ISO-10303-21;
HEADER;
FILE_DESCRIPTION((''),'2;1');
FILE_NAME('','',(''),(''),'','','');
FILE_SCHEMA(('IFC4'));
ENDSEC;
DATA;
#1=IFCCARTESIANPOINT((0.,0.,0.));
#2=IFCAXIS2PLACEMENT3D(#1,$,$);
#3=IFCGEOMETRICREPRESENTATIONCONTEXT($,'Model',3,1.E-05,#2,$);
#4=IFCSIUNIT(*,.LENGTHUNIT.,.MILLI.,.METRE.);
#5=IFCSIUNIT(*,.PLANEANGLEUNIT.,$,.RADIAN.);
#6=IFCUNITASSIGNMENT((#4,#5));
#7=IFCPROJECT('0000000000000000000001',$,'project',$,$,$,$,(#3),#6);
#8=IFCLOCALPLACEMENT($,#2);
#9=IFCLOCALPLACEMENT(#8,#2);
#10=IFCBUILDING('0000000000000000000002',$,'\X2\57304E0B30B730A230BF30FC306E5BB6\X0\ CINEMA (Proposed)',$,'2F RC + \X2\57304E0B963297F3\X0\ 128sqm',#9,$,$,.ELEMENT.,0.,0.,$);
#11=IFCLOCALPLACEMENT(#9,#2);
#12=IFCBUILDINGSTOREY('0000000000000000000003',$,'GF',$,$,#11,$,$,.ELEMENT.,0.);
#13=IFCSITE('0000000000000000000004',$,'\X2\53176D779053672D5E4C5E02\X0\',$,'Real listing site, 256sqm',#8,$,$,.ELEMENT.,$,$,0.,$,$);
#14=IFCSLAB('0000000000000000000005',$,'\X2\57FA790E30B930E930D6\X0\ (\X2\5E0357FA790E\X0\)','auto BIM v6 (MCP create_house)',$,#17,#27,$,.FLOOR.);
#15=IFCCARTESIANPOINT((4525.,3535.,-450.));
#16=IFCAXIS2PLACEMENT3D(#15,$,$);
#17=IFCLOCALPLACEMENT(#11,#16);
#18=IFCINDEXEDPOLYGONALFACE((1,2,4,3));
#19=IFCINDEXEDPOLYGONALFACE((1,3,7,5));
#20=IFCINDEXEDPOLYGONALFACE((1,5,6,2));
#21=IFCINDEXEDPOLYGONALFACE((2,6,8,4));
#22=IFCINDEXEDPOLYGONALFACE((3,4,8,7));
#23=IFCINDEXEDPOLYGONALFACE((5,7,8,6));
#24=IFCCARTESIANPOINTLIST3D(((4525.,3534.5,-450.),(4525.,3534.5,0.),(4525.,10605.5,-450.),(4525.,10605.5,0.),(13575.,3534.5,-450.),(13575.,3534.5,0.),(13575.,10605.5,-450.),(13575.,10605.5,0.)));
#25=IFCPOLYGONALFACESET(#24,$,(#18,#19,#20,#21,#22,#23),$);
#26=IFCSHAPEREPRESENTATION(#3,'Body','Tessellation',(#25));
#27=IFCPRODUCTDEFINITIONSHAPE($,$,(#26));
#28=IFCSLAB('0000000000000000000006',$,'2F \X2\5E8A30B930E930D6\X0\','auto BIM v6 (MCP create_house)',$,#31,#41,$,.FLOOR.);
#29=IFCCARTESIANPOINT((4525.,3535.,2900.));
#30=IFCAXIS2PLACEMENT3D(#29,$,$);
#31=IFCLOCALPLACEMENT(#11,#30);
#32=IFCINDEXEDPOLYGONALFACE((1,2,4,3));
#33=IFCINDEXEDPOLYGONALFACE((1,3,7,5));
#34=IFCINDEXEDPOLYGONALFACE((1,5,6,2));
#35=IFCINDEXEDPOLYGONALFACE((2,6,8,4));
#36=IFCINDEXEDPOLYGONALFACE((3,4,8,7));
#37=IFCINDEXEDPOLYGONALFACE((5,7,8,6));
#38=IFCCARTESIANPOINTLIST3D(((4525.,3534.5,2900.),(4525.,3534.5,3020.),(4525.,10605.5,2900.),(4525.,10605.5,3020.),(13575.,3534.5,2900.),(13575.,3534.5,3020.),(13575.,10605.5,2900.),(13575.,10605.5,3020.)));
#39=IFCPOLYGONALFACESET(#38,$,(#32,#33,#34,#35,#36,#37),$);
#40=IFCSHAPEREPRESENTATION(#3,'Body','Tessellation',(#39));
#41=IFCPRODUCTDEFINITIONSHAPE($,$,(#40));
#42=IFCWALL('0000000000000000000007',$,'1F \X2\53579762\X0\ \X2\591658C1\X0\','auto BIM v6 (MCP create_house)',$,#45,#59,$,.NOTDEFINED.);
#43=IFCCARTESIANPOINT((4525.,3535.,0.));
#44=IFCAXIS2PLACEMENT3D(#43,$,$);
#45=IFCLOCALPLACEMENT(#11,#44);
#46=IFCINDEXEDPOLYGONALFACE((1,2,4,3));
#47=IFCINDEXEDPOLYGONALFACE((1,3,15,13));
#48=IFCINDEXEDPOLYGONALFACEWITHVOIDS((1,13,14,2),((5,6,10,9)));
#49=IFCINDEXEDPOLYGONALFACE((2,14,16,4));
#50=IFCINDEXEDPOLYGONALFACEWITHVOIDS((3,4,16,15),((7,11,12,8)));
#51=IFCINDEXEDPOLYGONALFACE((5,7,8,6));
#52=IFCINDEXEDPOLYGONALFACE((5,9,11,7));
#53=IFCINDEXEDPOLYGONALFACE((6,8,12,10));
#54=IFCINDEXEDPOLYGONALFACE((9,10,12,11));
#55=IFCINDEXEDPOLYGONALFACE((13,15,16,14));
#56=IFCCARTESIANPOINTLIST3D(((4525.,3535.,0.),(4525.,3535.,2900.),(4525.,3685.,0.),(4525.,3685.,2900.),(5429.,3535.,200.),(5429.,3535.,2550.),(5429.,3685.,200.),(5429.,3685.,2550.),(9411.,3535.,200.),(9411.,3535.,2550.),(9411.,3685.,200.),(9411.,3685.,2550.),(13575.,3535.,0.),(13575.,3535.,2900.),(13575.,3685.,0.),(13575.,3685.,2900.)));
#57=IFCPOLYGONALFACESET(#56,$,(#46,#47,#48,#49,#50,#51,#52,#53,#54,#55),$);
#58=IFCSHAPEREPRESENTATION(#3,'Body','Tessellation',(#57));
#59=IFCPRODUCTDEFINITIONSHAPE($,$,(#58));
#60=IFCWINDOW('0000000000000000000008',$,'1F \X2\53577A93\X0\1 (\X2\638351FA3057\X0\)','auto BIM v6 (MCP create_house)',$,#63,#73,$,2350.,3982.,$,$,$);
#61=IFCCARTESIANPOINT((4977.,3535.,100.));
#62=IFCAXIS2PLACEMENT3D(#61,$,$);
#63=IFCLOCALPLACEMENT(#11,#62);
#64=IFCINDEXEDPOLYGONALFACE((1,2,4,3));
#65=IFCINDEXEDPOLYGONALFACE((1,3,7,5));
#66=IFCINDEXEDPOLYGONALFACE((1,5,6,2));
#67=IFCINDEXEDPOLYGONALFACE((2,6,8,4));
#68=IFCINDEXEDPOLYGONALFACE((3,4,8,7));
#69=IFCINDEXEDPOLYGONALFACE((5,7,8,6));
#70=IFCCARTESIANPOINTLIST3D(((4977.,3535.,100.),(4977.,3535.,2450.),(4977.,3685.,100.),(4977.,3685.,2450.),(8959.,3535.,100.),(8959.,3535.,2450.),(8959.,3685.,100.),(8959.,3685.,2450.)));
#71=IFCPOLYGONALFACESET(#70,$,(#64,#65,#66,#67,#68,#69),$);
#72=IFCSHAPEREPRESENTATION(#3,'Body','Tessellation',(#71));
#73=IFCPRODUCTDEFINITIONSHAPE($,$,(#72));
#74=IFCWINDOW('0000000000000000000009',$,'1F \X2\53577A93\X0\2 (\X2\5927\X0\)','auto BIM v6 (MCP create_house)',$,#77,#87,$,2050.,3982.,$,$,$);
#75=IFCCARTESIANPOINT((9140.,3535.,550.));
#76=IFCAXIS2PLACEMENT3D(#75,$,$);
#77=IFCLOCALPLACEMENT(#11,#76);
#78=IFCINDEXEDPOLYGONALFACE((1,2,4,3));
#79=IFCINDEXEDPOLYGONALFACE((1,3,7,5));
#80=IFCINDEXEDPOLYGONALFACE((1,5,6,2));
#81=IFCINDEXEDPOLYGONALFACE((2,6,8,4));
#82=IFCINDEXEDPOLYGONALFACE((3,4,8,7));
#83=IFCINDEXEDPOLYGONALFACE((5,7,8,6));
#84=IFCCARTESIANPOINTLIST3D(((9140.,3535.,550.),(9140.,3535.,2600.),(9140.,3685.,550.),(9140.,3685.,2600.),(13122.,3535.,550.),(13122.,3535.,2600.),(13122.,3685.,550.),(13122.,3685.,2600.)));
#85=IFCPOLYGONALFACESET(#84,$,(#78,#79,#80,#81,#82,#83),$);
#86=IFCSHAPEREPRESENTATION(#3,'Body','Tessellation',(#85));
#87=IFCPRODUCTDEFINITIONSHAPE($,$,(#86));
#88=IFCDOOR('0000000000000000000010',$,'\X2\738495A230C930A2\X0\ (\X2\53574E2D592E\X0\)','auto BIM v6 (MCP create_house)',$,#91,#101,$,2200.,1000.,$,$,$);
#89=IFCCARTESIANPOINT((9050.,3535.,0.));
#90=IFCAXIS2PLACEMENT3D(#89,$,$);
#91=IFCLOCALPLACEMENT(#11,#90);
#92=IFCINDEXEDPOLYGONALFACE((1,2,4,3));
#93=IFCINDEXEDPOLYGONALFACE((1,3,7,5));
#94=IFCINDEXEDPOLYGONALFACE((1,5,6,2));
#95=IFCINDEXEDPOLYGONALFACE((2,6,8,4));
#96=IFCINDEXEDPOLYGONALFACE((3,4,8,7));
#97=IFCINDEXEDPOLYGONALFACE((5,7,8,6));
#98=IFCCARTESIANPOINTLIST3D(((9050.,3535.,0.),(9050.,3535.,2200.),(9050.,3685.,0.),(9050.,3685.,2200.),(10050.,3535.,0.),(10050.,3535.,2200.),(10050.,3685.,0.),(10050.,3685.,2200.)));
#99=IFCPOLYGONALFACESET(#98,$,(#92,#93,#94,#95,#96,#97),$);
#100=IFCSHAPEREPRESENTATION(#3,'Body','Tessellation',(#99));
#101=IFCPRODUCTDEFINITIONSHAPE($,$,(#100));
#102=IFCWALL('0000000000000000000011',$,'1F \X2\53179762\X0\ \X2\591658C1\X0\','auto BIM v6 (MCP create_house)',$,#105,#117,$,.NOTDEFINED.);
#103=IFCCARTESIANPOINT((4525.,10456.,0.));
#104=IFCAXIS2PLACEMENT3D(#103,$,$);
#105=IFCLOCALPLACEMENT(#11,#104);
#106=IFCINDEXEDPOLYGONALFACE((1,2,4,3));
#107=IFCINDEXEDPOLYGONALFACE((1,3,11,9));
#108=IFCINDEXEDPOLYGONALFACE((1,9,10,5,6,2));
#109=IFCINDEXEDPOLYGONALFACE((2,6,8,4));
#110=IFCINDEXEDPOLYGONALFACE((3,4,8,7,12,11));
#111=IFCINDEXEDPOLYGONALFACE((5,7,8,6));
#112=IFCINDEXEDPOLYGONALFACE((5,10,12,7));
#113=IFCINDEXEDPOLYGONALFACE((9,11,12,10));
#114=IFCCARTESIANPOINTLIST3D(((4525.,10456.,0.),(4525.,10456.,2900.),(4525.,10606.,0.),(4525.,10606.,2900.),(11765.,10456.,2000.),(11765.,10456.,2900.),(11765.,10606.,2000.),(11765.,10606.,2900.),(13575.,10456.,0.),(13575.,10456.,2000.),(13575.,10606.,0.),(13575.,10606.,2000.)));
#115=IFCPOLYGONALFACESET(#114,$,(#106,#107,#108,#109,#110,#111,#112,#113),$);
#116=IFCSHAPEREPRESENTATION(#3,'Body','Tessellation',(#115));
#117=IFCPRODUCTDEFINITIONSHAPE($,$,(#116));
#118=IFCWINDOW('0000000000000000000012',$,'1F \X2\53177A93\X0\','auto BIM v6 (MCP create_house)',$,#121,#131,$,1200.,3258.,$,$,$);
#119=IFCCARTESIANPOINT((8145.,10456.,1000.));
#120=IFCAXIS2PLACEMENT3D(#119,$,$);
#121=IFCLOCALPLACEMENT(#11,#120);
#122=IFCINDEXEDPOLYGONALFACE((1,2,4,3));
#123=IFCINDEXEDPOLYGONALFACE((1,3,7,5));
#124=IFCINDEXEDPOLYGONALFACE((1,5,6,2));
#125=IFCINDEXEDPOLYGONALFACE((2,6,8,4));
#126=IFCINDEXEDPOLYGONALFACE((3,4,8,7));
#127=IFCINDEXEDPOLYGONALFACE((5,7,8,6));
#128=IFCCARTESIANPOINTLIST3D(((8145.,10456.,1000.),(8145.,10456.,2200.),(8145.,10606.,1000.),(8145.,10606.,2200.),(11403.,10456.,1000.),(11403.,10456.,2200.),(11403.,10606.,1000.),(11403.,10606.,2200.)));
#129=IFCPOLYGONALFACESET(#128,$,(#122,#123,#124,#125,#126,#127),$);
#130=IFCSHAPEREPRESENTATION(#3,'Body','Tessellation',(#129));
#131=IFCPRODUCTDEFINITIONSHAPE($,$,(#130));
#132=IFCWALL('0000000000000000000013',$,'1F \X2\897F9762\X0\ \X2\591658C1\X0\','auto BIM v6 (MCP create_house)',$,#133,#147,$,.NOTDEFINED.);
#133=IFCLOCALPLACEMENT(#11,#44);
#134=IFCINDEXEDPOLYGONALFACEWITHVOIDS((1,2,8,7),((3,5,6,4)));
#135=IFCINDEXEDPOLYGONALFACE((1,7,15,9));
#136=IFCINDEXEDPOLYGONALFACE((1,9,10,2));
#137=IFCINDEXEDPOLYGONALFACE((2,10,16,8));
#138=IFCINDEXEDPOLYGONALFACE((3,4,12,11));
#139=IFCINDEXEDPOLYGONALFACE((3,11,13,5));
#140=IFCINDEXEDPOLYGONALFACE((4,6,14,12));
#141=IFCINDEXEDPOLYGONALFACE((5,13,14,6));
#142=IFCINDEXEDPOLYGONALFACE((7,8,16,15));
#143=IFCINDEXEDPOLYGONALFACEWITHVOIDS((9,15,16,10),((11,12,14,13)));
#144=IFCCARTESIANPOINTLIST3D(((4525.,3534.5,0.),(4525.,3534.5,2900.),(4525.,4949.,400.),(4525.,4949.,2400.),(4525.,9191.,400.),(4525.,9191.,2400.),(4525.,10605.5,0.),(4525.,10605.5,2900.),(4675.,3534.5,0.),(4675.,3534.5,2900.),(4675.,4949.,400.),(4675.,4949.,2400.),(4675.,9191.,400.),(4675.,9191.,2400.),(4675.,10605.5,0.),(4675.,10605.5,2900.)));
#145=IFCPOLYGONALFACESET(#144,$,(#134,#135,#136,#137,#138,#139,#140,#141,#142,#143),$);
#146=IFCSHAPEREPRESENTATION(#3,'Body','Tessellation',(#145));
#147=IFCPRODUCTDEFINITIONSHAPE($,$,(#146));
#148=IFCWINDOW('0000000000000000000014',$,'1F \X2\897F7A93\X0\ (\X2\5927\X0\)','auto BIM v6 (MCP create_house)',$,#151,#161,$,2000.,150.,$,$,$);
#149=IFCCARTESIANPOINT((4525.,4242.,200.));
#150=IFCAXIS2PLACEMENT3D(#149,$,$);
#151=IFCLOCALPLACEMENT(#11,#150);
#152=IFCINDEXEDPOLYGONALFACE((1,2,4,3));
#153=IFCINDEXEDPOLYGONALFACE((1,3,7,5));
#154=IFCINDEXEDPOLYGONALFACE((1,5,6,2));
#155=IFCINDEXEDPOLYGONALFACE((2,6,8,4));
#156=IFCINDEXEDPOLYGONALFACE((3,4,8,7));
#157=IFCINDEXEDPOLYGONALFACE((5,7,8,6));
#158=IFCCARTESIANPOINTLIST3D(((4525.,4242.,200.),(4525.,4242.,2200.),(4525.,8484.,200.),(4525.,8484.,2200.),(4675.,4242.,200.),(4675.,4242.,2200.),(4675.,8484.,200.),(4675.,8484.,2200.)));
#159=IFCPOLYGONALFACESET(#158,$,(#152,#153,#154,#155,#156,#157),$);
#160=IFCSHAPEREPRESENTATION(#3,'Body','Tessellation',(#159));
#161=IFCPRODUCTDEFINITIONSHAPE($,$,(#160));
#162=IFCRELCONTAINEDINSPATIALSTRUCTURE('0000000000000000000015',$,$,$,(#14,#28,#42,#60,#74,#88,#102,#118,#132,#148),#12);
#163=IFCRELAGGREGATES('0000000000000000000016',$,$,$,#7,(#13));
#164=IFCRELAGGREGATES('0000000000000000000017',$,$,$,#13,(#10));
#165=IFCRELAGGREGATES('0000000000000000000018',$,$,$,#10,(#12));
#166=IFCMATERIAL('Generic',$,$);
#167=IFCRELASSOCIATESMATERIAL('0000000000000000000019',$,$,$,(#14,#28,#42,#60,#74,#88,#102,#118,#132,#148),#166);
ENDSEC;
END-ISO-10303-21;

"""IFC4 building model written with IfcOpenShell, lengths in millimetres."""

from ifc_helpers import new_model, si_unit, frame, frame_2d, origin, place, context, project, spatial, rectangle, extrude, material, element, fill, save


model = new_model("IFC4")

# Units and contexts
model_context = context("Model", 3, precision=1e-05, world=origin())
ifc_project = project(units=[si_unit("LENGTHUNIT", "METRE", prefix="MILLI"), si_unit("PLANEANGLEUNIT", "RADIAN")], contexts=[model_context])

# Site, building, storey
site_placement = place(None, origin())
site = spatial("IfcSite", under=ifc_project, at=site_placement, Name="北海道札幌市", ObjectType="Real listing site, 256sqm", CompositionType="ELEMENT", RefElevation=0.0)
building_placement = place(site_placement, origin())
building = spatial("IfcBuilding", under=site, at=building_placement, Name="地下シアターの家 CINEMA (Proposed)", ObjectType="2F RC + 地下防音 128sqm", CompositionType="ELEMENT", ElevationOfRefHeight=0.0, ElevationOfTerrain=0.0)
storey_placement = place(building_placement, origin())
storey = spatial("IfcBuildingStorey", under=building, at=storey_placement, Name="GF", CompositionType="ELEMENT", Elevation=0.0)

# Slabs
ifc_material = material(Name="Generic")
slab_1_placement = place(storey_placement, frame((4525.0, 3535.0, -450.0)))
element("IfcSlab", 1, at=slab_1_placement, inside=storey, material=ifc_material, Name="基礎スラブ (布基礎)", Description="auto BIM v6 (MCP create_house)", PredefinedType="FLOOR", context=model_context, shape_type="SweptSolid", body=[
    extrude(rectangle(XDim=9050.0, YDim=7071.0, at=frame_2d((4525.0, 3535.0))), frame((4525.0, 3535.0, -450.0)), (0.0, 0.0, 1.0), 450.0),
])
slab_2_placement = place(storey_placement, frame((4525.0, 3535.0, 2900.0)))
element("IfcSlab", 2, at=slab_2_placement, inside=storey, material=ifc_material, Name="2F 床スラブ", Description="auto BIM v6 (MCP create_house)", PredefinedType="FLOOR", context=model_context, shape_type="SweptSolid", body=[
    extrude(rectangle(XDim=9050.0, YDim=7071.0, at=frame_2d((4525.0, 3535.0))), frame((4525.0, 3535.0, 2900.0)), (0.0, 0.0, 1.0), 120.0),
])

# Wall, openings, windows, door
wall_1_placement = place(storey_placement, frame((4525.0, 3535.0, 0.0)))
wall_1 = element("IfcWall", 3, at=wall_1_placement, inside=storey, material=ifc_material, Name="1F 南面 外壁", Description="auto BIM v6 (MCP create_house)", PredefinedType="NOTDEFINED", context=model_context, shape_type="SweptSolid", body=[
    extrude(rectangle(XDim=9050.0, YDim=150.0, at=frame_2d((4525.0, 75.0))), frame((4525.0, 3535.0, 0.0)), (0.0, 0.0, 1.0), 2900.0),
])
opening_1_placement = place(storey_placement, frame((4977.0, 3535.0, 100.0)))
opening_1 = element("IfcOpeningElement", 4, at=opening_1_placement, cuts=wall_1, PredefinedType="NOTDEFINED", context=model_context, shape_type="SweptSolid", body=[
    extrude(rectangle(XDim=3982.0, YDim=150.0, at=frame_2d((1991.0, 75.0))), frame((4977.0, 3535.0, 100.0)), (0.0, 0.0, 1.0), 2350.0),
])
opening_2_placement = place(storey_placement, frame((9140.0, 3535.0, 550.0)))
opening_2 = element("IfcOpeningElement", 5, at=opening_2_placement, cuts=wall_1, PredefinedType="NOTDEFINED", context=model_context, shape_type="SweptSolid", body=[
    extrude(rectangle(XDim=3982.0, YDim=150.0, at=frame_2d((1991.0, 75.0))), frame((9140.0, 3535.0, 550.0)), (0.0, 0.0, 1.0), 2050.0),
])
opening_3_placement = place(storey_placement, frame((9050.0, 3535.0, 0.0)))
opening_3 = element("IfcOpeningElement", 6, at=opening_3_placement, cuts=wall_1, PredefinedType="NOTDEFINED", context=model_context, shape_type="SweptSolid", body=[
    extrude(rectangle(XDim=1000.0, YDim=150.0, at=frame_2d((500.0, 75.0))), frame((9050.0, 3535.0, 0.0)), (0.0, 0.0, 1.0), 2200.0),
])
window_1_placement = place(storey_placement, frame((4977.0, 3535.0, 100.0)))
window_1 = element("IfcWindow", 7, at=window_1_placement, inside=storey, material=ifc_material, Name="1F 南窓1 (掃出し)", Description="auto BIM v6 (MCP create_house)", OverallHeight=2350.0, OverallWidth=3982.0, context=model_context, shape_type="SweptSolid", body=[
    extrude(rectangle(XDim=3982.0, YDim=150.0, at=frame_2d((1991.0, 75.0))), frame((4977.0, 3535.0, 100.0)), (0.0, 0.0, 1.0), 2350.0),
])
fill(opening_1, window_1)
window_2_placement = place(storey_placement, frame((9140.0, 3535.0, 550.0)))
window_2 = element("IfcWindow", 8, at=window_2_placement, inside=storey, material=ifc_material, Name="1F 南窓2 (大)", Description="auto BIM v6 (MCP create_house)", OverallHeight=2050.0, OverallWidth=3982.0, context=model_context, shape_type="SweptSolid", body=[
    extrude(rectangle(XDim=3982.0, YDim=150.0, at=frame_2d((1991.0, 75.0))), frame((9140.0, 3535.0, 550.0)), (0.0, 0.0, 1.0), 2050.0),
])
fill(opening_2, window_2)
door_placement = place(storey_placement, frame((9050.0, 3535.0, 0.0)))
door = element("IfcDoor", 9, at=door_placement, inside=storey, material=ifc_material, Name="玄関ドア (南中央)", Description="auto BIM v6 (MCP create_house)", OverallHeight=2200.0, OverallWidth=1000.0, context=model_context, shape_type="SweptSolid", body=[
    extrude(rectangle(XDim=1000.0, YDim=150.0, at=frame_2d((500.0, 75.0))), frame((9050.0, 3535.0, 0.0)), (0.0, 0.0, 1.0), 2200.0),
])
fill(opening_3, door)

# Walls, openings, windows
wall_2_placement = place(storey_placement, frame((4525.0, 10456.0, 0.0)))
wall_2 = element("IfcWall", 10, at=wall_2_placement, inside=storey, material=ifc_material, Name="1F 北面 外壁", Description="auto BIM v6 (MCP create_house)", PredefinedType="NOTDEFINED", context=model_context, shape_type="SweptSolid", body=[
    extrude(rectangle(XDim=9050.0, YDim=150.0, at=frame_2d((4525.0, 75.0))), frame((4525.0, 10456.0, 0.0)), (0.0, 0.0, 1.0), 2900.0),
])
opening_4_placement = place(storey_placement, frame((8145.0, 10456.0, 1000.0)))
opening_4 = element("IfcOpeningElement", 11, at=opening_4_placement, cuts=wall_2, PredefinedType="NOTDEFINED", context=model_context, shape_type="SweptSolid", body=[
    extrude(rectangle(XDim=3258.0, YDim=150.0, at=frame_2d((1629.0, 75.0))), frame((8145.0, 10456.0, 1000.0)), (0.0, 0.0, 1.0), 1200.0),
])
window_3_placement = place(storey_placement, frame((8145.0, 10456.0, 1000.0)))
window_3 = element("IfcWindow", 12, at=window_3_placement, inside=storey, material=ifc_material, Name="1F 北窓", Description="auto BIM v6 (MCP create_house)", OverallHeight=1200.0, OverallWidth=3258.0, context=model_context, shape_type="SweptSolid", body=[
    extrude(rectangle(XDim=3258.0, YDim=150.0, at=frame_2d((1629.0, 75.0))), frame((8145.0, 10456.0, 1000.0)), (0.0, 0.0, 1.0), 1200.0),
])
fill(opening_4, window_3)
wall_3_placement = place(storey_placement, frame((4525.0, 3535.0, 0.0)))
wall_3 = element("IfcWall", 13, at=wall_3_placement, inside=storey, material=ifc_material, Name="1F 西面 外壁", Description="auto BIM v6 (MCP create_house)", PredefinedType="NOTDEFINED", context=model_context, shape_type="SweptSolid", body=[
    extrude(rectangle(XDim=150.0, YDim=7071.0, at=frame_2d((75.0, 3535.0))), frame((4525.0, 3535.0, 0.0)), (0.0, 0.0, 1.0), 2900.0),
])
opening_5_placement = place(storey_placement, frame((4525.0, 4242.0, 200.0)))
opening_5 = element("IfcOpeningElement", 14, at=opening_5_placement, cuts=wall_3, PredefinedType="NOTDEFINED", context=model_context, shape_type="SweptSolid", body=[
    extrude(rectangle(XDim=150.0, YDim=4242.0, at=frame_2d((75.0, 2121.0))), frame((4525.0, 4242.0, 200.0)), (0.0, 0.0, 1.0), 2000.0),
])
window_4_placement = place(storey_placement, frame((4525.0, 4242.0, 200.0)))
window_4 = element("IfcWindow", 15, at=window_4_placement, inside=storey, material=ifc_material, Name="1F 西窓 (大)", Description="auto BIM v6 (MCP create_house)", OverallHeight=2000.0, OverallWidth=150.0, context=model_context, shape_type="SweptSolid", body=[
    extrude(rectangle(XDim=150.0, YDim=4242.0, at=frame_2d((75.0, 2121.0))), frame((4525.0, 4242.0, 200.0)), (0.0, 0.0, 1.0), 2000.0),
])
fill(opening_5, window_4)

save(model, "model.ifc")
